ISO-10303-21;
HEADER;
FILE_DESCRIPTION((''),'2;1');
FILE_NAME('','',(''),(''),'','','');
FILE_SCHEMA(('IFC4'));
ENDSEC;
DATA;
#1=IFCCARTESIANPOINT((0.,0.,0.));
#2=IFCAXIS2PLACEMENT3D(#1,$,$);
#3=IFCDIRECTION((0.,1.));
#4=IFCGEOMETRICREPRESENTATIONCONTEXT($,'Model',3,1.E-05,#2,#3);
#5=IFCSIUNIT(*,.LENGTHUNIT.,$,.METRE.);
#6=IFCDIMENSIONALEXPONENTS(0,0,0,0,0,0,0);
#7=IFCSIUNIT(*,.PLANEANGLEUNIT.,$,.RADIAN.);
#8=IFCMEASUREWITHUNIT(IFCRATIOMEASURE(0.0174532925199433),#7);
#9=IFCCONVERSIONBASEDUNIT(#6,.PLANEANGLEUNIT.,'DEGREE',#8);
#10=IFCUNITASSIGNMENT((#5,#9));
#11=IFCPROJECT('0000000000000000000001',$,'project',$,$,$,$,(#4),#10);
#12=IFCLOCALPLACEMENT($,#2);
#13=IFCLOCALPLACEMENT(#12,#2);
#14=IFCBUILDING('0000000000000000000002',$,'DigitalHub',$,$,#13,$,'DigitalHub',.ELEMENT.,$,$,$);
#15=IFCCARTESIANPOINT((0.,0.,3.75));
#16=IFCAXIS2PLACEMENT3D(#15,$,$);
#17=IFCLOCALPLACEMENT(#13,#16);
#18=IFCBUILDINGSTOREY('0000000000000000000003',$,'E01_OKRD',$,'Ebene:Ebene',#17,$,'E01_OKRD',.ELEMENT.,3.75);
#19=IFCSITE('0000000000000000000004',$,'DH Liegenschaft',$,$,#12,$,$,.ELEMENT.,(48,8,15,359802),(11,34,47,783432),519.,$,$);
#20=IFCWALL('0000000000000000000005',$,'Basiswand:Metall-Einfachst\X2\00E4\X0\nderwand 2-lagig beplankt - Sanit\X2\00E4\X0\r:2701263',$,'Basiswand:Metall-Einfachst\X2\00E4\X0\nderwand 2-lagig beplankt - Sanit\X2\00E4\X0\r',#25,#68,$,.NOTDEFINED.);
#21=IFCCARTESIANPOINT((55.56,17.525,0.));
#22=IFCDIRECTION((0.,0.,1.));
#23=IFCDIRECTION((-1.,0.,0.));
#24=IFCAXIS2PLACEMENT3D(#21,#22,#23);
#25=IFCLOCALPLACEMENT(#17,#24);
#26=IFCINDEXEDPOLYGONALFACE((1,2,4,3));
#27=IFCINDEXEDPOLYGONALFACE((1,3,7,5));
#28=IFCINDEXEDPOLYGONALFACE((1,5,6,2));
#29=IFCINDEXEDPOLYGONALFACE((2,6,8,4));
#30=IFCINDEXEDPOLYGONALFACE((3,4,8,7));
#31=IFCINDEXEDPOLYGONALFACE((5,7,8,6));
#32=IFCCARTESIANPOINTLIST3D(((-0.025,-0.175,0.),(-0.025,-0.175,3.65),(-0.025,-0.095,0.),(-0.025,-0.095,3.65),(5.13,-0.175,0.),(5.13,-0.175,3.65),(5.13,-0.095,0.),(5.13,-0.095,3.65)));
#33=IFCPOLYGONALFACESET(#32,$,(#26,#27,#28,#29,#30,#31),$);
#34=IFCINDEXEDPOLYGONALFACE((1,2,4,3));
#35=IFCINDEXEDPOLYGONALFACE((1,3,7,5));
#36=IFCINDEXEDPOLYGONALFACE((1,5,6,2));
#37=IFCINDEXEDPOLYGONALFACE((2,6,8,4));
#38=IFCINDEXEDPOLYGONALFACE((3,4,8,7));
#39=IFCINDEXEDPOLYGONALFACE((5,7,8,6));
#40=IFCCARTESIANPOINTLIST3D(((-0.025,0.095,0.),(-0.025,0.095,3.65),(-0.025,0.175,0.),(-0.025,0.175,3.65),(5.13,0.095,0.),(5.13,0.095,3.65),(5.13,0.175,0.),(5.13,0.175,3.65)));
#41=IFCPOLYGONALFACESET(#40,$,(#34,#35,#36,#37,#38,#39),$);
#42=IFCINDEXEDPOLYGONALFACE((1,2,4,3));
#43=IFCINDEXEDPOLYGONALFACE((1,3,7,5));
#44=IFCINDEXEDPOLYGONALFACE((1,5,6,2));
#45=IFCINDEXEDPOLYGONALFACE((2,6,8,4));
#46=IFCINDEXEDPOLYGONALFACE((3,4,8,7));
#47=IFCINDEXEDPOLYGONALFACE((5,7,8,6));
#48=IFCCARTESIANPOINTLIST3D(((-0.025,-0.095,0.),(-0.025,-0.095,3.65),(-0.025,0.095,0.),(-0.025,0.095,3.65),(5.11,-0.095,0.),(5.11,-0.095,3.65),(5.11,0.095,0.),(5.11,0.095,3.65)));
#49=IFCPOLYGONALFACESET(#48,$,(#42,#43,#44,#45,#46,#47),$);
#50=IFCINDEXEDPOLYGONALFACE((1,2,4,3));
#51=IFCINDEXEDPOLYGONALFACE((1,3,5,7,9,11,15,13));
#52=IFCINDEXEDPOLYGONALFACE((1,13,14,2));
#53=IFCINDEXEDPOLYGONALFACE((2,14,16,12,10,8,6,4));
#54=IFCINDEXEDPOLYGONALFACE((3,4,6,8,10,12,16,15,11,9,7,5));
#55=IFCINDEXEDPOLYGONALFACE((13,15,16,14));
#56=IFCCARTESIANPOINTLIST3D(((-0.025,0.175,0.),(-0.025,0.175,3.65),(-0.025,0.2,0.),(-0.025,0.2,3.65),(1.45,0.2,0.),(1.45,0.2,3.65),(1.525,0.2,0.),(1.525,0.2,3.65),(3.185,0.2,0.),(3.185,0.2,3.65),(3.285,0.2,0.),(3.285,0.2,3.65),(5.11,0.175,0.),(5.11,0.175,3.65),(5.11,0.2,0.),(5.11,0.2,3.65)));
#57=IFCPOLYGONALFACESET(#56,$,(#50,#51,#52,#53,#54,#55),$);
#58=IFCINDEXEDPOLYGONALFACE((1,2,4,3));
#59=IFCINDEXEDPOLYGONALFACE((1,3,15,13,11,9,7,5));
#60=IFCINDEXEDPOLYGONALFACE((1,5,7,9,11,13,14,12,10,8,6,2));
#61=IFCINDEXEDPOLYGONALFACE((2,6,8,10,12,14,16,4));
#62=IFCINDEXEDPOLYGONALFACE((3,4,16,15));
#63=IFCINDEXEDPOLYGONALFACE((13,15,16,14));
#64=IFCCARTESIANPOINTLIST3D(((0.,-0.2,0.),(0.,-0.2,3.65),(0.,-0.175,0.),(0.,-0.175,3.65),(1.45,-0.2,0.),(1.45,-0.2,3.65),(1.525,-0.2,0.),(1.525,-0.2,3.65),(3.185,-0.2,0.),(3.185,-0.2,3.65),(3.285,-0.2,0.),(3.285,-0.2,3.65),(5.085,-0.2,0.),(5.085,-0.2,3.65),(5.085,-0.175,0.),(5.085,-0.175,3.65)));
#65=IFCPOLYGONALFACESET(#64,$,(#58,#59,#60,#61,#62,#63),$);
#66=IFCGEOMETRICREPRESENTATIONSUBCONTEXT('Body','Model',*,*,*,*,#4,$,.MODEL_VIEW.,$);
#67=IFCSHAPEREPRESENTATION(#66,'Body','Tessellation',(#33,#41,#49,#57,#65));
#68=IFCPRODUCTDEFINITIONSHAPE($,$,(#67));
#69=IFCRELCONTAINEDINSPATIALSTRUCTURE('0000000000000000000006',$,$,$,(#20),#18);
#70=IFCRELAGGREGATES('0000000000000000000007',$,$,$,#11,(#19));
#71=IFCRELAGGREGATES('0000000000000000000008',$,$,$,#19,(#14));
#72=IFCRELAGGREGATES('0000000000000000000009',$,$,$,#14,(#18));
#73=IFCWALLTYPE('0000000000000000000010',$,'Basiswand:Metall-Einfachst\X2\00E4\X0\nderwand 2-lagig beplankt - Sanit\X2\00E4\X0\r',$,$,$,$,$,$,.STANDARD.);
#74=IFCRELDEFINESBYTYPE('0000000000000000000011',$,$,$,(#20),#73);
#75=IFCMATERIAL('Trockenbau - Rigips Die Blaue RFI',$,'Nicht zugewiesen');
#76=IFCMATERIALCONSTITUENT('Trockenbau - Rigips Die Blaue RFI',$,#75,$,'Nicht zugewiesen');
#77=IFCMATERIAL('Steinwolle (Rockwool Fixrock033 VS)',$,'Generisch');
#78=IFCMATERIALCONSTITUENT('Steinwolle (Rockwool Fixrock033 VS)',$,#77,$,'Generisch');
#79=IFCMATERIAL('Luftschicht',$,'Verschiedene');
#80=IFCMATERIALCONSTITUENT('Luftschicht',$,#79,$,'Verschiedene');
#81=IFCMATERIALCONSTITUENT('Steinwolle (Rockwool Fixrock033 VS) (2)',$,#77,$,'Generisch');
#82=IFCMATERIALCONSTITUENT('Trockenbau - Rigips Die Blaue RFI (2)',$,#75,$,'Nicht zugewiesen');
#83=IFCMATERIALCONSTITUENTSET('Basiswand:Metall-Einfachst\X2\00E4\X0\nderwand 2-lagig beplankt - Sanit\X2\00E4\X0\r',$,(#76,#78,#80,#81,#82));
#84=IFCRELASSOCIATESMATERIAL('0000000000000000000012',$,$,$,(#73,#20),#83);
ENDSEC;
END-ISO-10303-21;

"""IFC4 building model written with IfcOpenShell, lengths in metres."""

from ifc_helpers import new_model, entity, si_unit, converted_unit, direction, frame, origin, place, context, subcontext, project, spatial, indexed_curve, outline, extrude, material, constituent, constituent_set, type_object, element, save


model = new_model("IFC4")

# Units and contexts
model_context = context("Model", 3, precision=1e-05, world=origin(), true_north=direction((0.0, 1.0)))
body_context = subcontext(model_context, "Body", "Model", "MODEL_VIEW")
ifc_project = project(units=[si_unit("LENGTHUNIT", "METRE"), converted_unit("PLANEANGLEUNIT", "DEGREE", entity("IfcRatioMeasure", 0.0174532925199433), si_unit("PLANEANGLEUNIT", "RADIAN"), dimensions=[0, 0, 0, 0, 0, 0, 0])], contexts=[model_context])

# Site, building, storey
site_placement = place(None, frame((0.0, 0.0, 0.0)))
site = spatial("IfcSite", under=ifc_project, at=site_placement, Name="DH Liegenschaft", CompositionType="ELEMENT", RefLatitude=(48, 8, 15, 359802), RefLongitude=(11, 34, 47, 783432), RefElevation=519.0)
building_placement = place(site_placement, origin())
building = spatial("IfcBuilding", under=site, at=building_placement, Name="DigitalHub", LongName="DigitalHub", CompositionType="ELEMENT")
storey_placement = place(building_placement, frame((0.0, 0.0, 3.75)))
storey = spatial("IfcBuildingStorey", under=building, at=storey_placement, Name="E01_OKRD", ObjectType="Ebene:Ebene", LongName="E01_OKRD", CompositionType="ELEMENT", Elevation=3.75)

# Shared definitions
ifc_material_1 = material(Name="Trockenbau - Rigips Die Blaue RFI", Category="Nicht zugewiesen")

# Wall
ifc_constituent_1 = constituent(ifc_material_1, Name="Trockenbau - Rigips Die Blaue RFI", Category="Nicht zugewiesen")
ifc_material_2 = material(Name="Steinwolle (Rockwool Fixrock033 VS)", Category="Generisch")
ifc_constituent_2 = constituent(ifc_material_2, Name="Steinwolle (Rockwool Fixrock033 VS)", Category="Generisch")
ifc_material_3 = material(Name="Luftschicht", Category="Verschiedene")
ifc_constituent_3 = constituent(ifc_material_3, Name="Luftschicht", Category="Verschiedene")
ifc_constituent_4 = constituent(ifc_material_2, Name="Steinwolle (Rockwool Fixrock033 VS) (2)", Category="Generisch")
ifc_constituent_5 = constituent(ifc_material_1, Name="Trockenbau - Rigips Die Blaue RFI (2)", Category="Nicht zugewiesen")
ifc_constituent_set_1 = constituent_set(constituents=[ifc_constituent_1, ifc_constituent_2, ifc_constituent_3, ifc_constituent_4, ifc_constituent_5], Name="Basiswand:Metall-Einfachständerwand 2-lagig beplankt - Sanitär")
wall_type_1 = type_object("IfcWallType", Name="Basiswand:Metall-Einfachständerwand 2-lagig beplankt - Sanitär", PredefinedType="STANDARD", material=ifc_constituent_set_1)
wall_1_placement = place(storey_placement, frame((55.56, 17.525, 0.0), z_axis=(0.0, 0.0, 1.0), x_axis=(-1.0, 0.0, 0.0)))
element("IfcWall", 1, at=wall_1_placement, inside=storey, type_object=wall_type_1, material=ifc_constituent_set_1, Name="Basiswand:Metall-Einfachständerwand 2-lagig beplankt - Sanitär:2701263", ObjectType="Basiswand:Metall-Einfachständerwand 2-lagig beplankt - Sanitär", PredefinedType="NOTDEFINED", context=body_context, shape_type="SweptSolid", body=[
    extrude(outline(indexed_curve([(-2.5775, -0.04), (2.5775, -0.04), (2.5775, 0.04), (-2.5775, 0.04), (-2.5775, -0.04)], self_intersect=False)), frame((2.5525, -0.135, 0.0)), (0.0, 0.0, 1.0), 3.65),
    extrude(outline(indexed_curve([(-2.5775, -0.04), (2.5775, -0.04), (2.5775, 0.04), (-2.5775, 0.04), (-2.5775, -0.04)], self_intersect=False)), frame((2.5525, 0.135, 0.0)), (0.0, 0.0, 1.0), 3.65),
    extrude(outline(indexed_curve([(-2.5675, -0.095), (2.5675, -0.095), (2.5675, 0.095), (-2.5675, 0.095), (-2.5675, -0.095)], self_intersect=False)), frame((2.5425, 0.0, 0.0)), (0.0, 0.0, 1.0), 3.65),
    extrude(outline(indexed_curve([(-0.8331, -0.0062), (-0.7331, -0.0062), (0.9269, -0.0063), (1.0019, -0.0063), (2.4769, -0.0063), (2.4769, 0.0187), (-2.6581, 0.0188), (-2.6581, -0.0062), (-0.8331, -0.0062)], self_intersect=False)), frame((2.4519, 0.1937, 0.0), z_axis=(0.0, 0.0, 1.0), x_axis=(-1.0, 0.0, 0.0)), (0.0, 0.0, 1.0), 3.65),
    extrude(outline(indexed_curve([(-1.0019, -0.0062), (-0.9269, -0.0062), (0.7331, -0.0063), (0.8331, -0.0063), (2.6331, -0.0063), (2.6331, 0.0187), (-2.4519, 0.0188), (-2.4519, -0.0062), (-1.0019, -0.0062)], self_intersect=False)), frame((2.4519, -0.1938, 0.0)), (0.0, 0.0, 1.0), 3.65),
])

save(model, "model.ifc")
